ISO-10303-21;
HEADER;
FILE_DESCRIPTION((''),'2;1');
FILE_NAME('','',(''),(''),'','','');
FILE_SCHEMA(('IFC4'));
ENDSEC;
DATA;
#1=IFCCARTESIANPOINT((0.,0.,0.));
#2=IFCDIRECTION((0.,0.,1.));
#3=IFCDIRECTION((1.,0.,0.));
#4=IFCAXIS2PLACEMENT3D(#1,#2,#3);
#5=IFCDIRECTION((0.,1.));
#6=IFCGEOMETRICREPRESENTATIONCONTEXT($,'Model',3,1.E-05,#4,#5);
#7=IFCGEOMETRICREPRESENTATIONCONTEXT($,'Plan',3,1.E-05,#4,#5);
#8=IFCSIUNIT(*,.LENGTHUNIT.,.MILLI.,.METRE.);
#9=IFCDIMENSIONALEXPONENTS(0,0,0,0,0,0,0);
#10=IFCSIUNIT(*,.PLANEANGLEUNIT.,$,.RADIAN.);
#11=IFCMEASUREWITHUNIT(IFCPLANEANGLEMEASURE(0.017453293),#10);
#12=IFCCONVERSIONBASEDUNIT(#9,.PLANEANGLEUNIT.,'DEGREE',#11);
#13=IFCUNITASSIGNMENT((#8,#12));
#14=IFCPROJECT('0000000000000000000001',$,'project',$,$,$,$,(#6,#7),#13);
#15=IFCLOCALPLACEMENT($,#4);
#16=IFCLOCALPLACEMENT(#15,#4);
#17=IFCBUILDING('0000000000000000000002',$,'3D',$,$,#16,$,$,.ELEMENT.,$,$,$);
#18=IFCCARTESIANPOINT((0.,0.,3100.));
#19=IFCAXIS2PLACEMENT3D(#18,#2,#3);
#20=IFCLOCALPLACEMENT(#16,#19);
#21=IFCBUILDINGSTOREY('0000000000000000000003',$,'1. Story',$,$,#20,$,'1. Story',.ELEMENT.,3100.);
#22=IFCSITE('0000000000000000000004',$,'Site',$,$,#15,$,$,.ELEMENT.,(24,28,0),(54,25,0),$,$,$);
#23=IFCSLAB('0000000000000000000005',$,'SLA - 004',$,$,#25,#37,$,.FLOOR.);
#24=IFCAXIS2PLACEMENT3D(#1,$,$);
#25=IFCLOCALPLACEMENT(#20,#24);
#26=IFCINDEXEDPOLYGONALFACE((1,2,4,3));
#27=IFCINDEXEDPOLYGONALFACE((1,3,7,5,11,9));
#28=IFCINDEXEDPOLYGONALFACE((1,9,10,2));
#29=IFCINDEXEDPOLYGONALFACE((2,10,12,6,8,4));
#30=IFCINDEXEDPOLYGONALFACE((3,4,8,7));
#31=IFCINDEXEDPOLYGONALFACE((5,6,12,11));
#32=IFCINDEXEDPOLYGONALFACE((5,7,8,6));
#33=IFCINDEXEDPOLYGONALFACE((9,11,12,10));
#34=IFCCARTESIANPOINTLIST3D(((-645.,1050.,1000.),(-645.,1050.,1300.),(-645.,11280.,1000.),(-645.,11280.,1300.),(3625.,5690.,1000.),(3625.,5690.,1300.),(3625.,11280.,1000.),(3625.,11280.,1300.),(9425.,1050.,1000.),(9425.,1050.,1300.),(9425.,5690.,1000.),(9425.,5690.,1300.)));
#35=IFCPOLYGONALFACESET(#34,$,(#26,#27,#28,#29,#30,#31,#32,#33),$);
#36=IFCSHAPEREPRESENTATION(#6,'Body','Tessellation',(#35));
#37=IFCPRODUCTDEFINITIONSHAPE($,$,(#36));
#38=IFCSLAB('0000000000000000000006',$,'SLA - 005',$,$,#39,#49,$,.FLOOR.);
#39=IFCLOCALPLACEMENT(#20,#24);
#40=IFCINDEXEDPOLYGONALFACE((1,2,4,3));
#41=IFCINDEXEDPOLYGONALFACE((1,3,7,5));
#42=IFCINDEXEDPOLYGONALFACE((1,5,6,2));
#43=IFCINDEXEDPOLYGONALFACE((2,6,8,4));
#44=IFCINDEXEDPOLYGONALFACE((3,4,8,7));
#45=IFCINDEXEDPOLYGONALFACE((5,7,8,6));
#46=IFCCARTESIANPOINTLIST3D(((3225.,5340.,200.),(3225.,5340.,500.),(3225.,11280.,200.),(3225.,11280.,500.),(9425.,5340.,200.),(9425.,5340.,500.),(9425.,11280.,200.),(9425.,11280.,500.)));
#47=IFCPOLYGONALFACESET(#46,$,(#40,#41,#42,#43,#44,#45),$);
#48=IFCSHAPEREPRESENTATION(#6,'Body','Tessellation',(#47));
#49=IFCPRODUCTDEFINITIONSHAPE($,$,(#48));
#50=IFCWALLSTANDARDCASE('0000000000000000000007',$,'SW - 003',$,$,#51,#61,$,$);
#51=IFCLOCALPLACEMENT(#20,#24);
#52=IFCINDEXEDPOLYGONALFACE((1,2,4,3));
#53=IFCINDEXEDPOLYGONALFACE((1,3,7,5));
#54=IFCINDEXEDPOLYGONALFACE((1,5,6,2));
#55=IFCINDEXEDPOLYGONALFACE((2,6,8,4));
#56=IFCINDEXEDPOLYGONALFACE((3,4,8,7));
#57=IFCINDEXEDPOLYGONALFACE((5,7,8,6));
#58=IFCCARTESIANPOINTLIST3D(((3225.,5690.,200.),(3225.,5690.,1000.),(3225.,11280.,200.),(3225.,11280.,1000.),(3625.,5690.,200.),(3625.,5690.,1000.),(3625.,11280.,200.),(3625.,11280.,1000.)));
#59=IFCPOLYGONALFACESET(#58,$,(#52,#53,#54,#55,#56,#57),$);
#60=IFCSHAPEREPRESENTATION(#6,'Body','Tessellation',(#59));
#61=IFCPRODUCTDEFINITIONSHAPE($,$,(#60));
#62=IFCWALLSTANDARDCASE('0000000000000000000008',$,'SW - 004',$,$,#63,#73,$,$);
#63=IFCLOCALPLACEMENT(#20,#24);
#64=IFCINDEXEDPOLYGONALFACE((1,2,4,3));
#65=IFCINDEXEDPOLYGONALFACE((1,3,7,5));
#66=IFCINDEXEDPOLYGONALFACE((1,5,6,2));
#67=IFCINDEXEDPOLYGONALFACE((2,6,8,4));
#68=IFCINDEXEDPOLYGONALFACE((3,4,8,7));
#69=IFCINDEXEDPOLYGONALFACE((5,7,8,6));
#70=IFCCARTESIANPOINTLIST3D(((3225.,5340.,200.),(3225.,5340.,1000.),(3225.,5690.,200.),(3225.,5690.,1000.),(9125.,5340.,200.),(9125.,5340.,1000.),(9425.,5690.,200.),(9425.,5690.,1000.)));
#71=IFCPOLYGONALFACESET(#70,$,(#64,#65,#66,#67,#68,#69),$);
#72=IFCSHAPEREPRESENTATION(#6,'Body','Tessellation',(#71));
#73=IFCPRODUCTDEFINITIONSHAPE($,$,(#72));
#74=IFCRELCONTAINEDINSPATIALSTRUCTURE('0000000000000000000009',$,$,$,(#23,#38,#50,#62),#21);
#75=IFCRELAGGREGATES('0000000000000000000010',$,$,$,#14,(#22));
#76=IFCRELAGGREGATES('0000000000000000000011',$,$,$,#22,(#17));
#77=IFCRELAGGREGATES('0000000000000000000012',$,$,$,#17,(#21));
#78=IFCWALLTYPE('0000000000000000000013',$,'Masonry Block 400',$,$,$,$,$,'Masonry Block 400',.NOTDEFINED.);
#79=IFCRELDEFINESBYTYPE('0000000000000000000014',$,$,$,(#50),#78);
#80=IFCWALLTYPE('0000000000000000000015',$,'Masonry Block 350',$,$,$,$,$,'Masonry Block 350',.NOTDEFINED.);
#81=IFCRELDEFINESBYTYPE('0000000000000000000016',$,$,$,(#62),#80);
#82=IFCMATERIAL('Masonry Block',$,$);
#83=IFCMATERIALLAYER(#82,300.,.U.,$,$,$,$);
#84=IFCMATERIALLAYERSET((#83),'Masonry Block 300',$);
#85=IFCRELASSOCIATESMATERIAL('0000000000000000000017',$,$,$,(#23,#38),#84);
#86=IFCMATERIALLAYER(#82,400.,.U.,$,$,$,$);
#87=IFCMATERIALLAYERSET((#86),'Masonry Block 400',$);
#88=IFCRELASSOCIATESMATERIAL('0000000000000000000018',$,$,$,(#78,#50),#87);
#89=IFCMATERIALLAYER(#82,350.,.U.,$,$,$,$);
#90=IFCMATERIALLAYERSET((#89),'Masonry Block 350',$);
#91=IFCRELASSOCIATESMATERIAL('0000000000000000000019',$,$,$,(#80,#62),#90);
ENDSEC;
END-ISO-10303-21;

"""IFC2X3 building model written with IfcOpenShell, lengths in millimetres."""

from ifc_helpers import new_model, entity, si_unit, converted_unit, direction, frame, origin_with_axes, place, context, project, spatial, polyline, outline, extrude, material, layer, layer_set, layer_usage, type_object, element, save


model = new_model("IFC2X3")

# Units and contexts
model_context = context("Model", 3, precision=1e-05, world=origin_with_axes(), true_north=direction((0.0, 1.0)))
plan_context = context("Plan", 3, precision=1e-05, world=origin_with_axes(), true_north=direction((0.0, 1.0)))
ifc_project = project(units=[si_unit("LENGTHUNIT", "METRE", prefix="MILLI"), converted_unit("PLANEANGLEUNIT", "DEGREE", entity("IfcPlaneAngleMeasure", 0.017453293), si_unit("PLANEANGLEUNIT", "RADIAN"), dimensions=[0, 0, 0, 0, 0, 0, 0])], contexts=[model_context, plan_context])

# Site, building, storey
site_placement = place(None, origin_with_axes())
site = spatial("IfcSite", under=ifc_project, at=site_placement, Name="Site", CompositionType="ELEMENT", RefLatitude=(24, 28, 0), RefLongitude=(54, 25, 0))
building_placement = place(site_placement, origin_with_axes())
building = spatial("IfcBuilding", under=site, at=building_placement, Name="3D", CompositionType="ELEMENT")
storey_placement = place(building_placement, frame((0.0, 0.0, 3100.0), z_axis=(0.0, 0.0, 1.0), x_axis=(1.0, 0.0, 0.0)))
storey = spatial("IfcBuildingStorey", under=building, at=storey_placement, Name="1. Story", LongName="1. Story", CompositionType="ELEMENT", Elevation=3100.0)

# Slabs
ifc_material = material(Name="Masonry Block")
ifc_layer_1 = layer(ifc_material, 300.0, ventilated="UNKNOWN")
ifc_layer_set_1 = layer_set([ifc_layer_1], Name="Masonry Block 300")
ifc_layer_usage_1 = layer_usage(ifc_layer_set_1, "AXIS3", "NEGATIVE", 300.0)
slab_1_placement = place(storey_placement, frame((-645.0, 11280.0, 1000.0), z_axis=(0.0, 0.0, 1.0), x_axis=(1.0, 0.0, 0.0)))
element("IfcSlab", 1, at=slab_1_placement, inside=storey, material=ifc_layer_usage_1, Name="SLA - 004", PredefinedType="FLOOR", context=model_context, shape_type="SweptSolid", body=[
    extrude(outline(polyline([(0.0, 0.0), (4270.0, 0.0), (4270.0, -5590.0), (10070.0, -5590.0), (10070.0, -10230.0), (0.0, -10230.0), (0.0, 0.0)])), origin_with_axes(), (0.0, 0.0, 1.0), 300.0),
])
ifc_layer_usage_2 = layer_usage(ifc_layer_set_1, "AXIS3", "NEGATIVE", 300.0)
slab_2_placement = place(storey_placement, frame((3225.0, 11280.0, 200.0), z_axis=(0.0, 0.0, 1.0), x_axis=(1.0, 0.0, 0.0)))
element("IfcSlab", 2, at=slab_2_placement, inside=storey, material=ifc_layer_usage_2, Name="SLA - 005", PredefinedType="FLOOR", context=model_context, shape_type="SweptSolid", body=[
    extrude(outline(polyline([(0.0, 0.0), (6200.0, 0.0), (6200.0, -5940.0), (0.0, -5940.0), (0.0, 0.0)])), origin_with_axes(), (0.0, 0.0, 1.0), 300.0),
])

# Walls
ifc_layer_2 = layer(ifc_material, 400.0, ventilated="UNKNOWN")
ifc_layer_set_2 = layer_set([ifc_layer_2], Name="Masonry Block 400")
ifc_layer_usage_3 = layer_usage(ifc_layer_set_2, "AXIS2", "NEGATIVE", 0.0)
wall_type_1 = type_object("IfcWallType", Name="Masonry Block 400", ElementType="Masonry Block 400", PredefinedType="NOTDEFINED", material=ifc_layer_set_2)
wall_1_placement = place(storey_placement, frame((3625.0, 11280.0, 200.0), z_axis=(0.0, 0.0, 1.0), x_axis=(0.0, -1.0, 0.0)))
element("IfcWallStandardCase", 3, at=wall_1_placement, inside=storey, type_object=wall_type_1, material=ifc_layer_usage_3, Name="SW - 003", context=model_context, shape_type="SweptSolid", body=[
    extrude(outline(polyline([(0.0, -400.0), (5590.0, -400.0), (5590.0, 0.0), (0.0, 0.0), (0.0, -400.0)])), origin_with_axes(), (0.0, 0.0, 1.0), 800.0),
])
ifc_layer_3 = layer(ifc_material, 350.0, ventilated="UNKNOWN")
ifc_layer_set_3 = layer_set([ifc_layer_3], Name="Masonry Block 350")
ifc_layer_usage_4 = layer_usage(ifc_layer_set_3, "AXIS2", "NEGATIVE", 0.0)
wall_type_2 = type_object("IfcWallType", Name="Masonry Block 350", ElementType="Masonry Block 350", PredefinedType="NOTDEFINED", material=ifc_layer_set_3)
wall_2_placement = place(storey_placement, frame((9425.0, 5340.0, 200.0), z_axis=(0.0, 0.0, 1.0), x_axis=(-1.0, 0.0, 0.0)))
element("IfcWallStandardCase", 4, at=wall_2_placement, inside=storey, type_object=wall_type_2, material=ifc_layer_usage_4, Name="SW - 004", context=model_context, shape_type="SweptSolid", body=[
    extrude(outline(polyline([(0.0, -350.0), (6200.0, -350.0), (6200.0, 0.0), (300.0, 0.0), (0.0, -350.0)])), origin_with_axes(), (0.0, 0.0, 1.0), 800.0),
])

save(model, "model.ifc")
